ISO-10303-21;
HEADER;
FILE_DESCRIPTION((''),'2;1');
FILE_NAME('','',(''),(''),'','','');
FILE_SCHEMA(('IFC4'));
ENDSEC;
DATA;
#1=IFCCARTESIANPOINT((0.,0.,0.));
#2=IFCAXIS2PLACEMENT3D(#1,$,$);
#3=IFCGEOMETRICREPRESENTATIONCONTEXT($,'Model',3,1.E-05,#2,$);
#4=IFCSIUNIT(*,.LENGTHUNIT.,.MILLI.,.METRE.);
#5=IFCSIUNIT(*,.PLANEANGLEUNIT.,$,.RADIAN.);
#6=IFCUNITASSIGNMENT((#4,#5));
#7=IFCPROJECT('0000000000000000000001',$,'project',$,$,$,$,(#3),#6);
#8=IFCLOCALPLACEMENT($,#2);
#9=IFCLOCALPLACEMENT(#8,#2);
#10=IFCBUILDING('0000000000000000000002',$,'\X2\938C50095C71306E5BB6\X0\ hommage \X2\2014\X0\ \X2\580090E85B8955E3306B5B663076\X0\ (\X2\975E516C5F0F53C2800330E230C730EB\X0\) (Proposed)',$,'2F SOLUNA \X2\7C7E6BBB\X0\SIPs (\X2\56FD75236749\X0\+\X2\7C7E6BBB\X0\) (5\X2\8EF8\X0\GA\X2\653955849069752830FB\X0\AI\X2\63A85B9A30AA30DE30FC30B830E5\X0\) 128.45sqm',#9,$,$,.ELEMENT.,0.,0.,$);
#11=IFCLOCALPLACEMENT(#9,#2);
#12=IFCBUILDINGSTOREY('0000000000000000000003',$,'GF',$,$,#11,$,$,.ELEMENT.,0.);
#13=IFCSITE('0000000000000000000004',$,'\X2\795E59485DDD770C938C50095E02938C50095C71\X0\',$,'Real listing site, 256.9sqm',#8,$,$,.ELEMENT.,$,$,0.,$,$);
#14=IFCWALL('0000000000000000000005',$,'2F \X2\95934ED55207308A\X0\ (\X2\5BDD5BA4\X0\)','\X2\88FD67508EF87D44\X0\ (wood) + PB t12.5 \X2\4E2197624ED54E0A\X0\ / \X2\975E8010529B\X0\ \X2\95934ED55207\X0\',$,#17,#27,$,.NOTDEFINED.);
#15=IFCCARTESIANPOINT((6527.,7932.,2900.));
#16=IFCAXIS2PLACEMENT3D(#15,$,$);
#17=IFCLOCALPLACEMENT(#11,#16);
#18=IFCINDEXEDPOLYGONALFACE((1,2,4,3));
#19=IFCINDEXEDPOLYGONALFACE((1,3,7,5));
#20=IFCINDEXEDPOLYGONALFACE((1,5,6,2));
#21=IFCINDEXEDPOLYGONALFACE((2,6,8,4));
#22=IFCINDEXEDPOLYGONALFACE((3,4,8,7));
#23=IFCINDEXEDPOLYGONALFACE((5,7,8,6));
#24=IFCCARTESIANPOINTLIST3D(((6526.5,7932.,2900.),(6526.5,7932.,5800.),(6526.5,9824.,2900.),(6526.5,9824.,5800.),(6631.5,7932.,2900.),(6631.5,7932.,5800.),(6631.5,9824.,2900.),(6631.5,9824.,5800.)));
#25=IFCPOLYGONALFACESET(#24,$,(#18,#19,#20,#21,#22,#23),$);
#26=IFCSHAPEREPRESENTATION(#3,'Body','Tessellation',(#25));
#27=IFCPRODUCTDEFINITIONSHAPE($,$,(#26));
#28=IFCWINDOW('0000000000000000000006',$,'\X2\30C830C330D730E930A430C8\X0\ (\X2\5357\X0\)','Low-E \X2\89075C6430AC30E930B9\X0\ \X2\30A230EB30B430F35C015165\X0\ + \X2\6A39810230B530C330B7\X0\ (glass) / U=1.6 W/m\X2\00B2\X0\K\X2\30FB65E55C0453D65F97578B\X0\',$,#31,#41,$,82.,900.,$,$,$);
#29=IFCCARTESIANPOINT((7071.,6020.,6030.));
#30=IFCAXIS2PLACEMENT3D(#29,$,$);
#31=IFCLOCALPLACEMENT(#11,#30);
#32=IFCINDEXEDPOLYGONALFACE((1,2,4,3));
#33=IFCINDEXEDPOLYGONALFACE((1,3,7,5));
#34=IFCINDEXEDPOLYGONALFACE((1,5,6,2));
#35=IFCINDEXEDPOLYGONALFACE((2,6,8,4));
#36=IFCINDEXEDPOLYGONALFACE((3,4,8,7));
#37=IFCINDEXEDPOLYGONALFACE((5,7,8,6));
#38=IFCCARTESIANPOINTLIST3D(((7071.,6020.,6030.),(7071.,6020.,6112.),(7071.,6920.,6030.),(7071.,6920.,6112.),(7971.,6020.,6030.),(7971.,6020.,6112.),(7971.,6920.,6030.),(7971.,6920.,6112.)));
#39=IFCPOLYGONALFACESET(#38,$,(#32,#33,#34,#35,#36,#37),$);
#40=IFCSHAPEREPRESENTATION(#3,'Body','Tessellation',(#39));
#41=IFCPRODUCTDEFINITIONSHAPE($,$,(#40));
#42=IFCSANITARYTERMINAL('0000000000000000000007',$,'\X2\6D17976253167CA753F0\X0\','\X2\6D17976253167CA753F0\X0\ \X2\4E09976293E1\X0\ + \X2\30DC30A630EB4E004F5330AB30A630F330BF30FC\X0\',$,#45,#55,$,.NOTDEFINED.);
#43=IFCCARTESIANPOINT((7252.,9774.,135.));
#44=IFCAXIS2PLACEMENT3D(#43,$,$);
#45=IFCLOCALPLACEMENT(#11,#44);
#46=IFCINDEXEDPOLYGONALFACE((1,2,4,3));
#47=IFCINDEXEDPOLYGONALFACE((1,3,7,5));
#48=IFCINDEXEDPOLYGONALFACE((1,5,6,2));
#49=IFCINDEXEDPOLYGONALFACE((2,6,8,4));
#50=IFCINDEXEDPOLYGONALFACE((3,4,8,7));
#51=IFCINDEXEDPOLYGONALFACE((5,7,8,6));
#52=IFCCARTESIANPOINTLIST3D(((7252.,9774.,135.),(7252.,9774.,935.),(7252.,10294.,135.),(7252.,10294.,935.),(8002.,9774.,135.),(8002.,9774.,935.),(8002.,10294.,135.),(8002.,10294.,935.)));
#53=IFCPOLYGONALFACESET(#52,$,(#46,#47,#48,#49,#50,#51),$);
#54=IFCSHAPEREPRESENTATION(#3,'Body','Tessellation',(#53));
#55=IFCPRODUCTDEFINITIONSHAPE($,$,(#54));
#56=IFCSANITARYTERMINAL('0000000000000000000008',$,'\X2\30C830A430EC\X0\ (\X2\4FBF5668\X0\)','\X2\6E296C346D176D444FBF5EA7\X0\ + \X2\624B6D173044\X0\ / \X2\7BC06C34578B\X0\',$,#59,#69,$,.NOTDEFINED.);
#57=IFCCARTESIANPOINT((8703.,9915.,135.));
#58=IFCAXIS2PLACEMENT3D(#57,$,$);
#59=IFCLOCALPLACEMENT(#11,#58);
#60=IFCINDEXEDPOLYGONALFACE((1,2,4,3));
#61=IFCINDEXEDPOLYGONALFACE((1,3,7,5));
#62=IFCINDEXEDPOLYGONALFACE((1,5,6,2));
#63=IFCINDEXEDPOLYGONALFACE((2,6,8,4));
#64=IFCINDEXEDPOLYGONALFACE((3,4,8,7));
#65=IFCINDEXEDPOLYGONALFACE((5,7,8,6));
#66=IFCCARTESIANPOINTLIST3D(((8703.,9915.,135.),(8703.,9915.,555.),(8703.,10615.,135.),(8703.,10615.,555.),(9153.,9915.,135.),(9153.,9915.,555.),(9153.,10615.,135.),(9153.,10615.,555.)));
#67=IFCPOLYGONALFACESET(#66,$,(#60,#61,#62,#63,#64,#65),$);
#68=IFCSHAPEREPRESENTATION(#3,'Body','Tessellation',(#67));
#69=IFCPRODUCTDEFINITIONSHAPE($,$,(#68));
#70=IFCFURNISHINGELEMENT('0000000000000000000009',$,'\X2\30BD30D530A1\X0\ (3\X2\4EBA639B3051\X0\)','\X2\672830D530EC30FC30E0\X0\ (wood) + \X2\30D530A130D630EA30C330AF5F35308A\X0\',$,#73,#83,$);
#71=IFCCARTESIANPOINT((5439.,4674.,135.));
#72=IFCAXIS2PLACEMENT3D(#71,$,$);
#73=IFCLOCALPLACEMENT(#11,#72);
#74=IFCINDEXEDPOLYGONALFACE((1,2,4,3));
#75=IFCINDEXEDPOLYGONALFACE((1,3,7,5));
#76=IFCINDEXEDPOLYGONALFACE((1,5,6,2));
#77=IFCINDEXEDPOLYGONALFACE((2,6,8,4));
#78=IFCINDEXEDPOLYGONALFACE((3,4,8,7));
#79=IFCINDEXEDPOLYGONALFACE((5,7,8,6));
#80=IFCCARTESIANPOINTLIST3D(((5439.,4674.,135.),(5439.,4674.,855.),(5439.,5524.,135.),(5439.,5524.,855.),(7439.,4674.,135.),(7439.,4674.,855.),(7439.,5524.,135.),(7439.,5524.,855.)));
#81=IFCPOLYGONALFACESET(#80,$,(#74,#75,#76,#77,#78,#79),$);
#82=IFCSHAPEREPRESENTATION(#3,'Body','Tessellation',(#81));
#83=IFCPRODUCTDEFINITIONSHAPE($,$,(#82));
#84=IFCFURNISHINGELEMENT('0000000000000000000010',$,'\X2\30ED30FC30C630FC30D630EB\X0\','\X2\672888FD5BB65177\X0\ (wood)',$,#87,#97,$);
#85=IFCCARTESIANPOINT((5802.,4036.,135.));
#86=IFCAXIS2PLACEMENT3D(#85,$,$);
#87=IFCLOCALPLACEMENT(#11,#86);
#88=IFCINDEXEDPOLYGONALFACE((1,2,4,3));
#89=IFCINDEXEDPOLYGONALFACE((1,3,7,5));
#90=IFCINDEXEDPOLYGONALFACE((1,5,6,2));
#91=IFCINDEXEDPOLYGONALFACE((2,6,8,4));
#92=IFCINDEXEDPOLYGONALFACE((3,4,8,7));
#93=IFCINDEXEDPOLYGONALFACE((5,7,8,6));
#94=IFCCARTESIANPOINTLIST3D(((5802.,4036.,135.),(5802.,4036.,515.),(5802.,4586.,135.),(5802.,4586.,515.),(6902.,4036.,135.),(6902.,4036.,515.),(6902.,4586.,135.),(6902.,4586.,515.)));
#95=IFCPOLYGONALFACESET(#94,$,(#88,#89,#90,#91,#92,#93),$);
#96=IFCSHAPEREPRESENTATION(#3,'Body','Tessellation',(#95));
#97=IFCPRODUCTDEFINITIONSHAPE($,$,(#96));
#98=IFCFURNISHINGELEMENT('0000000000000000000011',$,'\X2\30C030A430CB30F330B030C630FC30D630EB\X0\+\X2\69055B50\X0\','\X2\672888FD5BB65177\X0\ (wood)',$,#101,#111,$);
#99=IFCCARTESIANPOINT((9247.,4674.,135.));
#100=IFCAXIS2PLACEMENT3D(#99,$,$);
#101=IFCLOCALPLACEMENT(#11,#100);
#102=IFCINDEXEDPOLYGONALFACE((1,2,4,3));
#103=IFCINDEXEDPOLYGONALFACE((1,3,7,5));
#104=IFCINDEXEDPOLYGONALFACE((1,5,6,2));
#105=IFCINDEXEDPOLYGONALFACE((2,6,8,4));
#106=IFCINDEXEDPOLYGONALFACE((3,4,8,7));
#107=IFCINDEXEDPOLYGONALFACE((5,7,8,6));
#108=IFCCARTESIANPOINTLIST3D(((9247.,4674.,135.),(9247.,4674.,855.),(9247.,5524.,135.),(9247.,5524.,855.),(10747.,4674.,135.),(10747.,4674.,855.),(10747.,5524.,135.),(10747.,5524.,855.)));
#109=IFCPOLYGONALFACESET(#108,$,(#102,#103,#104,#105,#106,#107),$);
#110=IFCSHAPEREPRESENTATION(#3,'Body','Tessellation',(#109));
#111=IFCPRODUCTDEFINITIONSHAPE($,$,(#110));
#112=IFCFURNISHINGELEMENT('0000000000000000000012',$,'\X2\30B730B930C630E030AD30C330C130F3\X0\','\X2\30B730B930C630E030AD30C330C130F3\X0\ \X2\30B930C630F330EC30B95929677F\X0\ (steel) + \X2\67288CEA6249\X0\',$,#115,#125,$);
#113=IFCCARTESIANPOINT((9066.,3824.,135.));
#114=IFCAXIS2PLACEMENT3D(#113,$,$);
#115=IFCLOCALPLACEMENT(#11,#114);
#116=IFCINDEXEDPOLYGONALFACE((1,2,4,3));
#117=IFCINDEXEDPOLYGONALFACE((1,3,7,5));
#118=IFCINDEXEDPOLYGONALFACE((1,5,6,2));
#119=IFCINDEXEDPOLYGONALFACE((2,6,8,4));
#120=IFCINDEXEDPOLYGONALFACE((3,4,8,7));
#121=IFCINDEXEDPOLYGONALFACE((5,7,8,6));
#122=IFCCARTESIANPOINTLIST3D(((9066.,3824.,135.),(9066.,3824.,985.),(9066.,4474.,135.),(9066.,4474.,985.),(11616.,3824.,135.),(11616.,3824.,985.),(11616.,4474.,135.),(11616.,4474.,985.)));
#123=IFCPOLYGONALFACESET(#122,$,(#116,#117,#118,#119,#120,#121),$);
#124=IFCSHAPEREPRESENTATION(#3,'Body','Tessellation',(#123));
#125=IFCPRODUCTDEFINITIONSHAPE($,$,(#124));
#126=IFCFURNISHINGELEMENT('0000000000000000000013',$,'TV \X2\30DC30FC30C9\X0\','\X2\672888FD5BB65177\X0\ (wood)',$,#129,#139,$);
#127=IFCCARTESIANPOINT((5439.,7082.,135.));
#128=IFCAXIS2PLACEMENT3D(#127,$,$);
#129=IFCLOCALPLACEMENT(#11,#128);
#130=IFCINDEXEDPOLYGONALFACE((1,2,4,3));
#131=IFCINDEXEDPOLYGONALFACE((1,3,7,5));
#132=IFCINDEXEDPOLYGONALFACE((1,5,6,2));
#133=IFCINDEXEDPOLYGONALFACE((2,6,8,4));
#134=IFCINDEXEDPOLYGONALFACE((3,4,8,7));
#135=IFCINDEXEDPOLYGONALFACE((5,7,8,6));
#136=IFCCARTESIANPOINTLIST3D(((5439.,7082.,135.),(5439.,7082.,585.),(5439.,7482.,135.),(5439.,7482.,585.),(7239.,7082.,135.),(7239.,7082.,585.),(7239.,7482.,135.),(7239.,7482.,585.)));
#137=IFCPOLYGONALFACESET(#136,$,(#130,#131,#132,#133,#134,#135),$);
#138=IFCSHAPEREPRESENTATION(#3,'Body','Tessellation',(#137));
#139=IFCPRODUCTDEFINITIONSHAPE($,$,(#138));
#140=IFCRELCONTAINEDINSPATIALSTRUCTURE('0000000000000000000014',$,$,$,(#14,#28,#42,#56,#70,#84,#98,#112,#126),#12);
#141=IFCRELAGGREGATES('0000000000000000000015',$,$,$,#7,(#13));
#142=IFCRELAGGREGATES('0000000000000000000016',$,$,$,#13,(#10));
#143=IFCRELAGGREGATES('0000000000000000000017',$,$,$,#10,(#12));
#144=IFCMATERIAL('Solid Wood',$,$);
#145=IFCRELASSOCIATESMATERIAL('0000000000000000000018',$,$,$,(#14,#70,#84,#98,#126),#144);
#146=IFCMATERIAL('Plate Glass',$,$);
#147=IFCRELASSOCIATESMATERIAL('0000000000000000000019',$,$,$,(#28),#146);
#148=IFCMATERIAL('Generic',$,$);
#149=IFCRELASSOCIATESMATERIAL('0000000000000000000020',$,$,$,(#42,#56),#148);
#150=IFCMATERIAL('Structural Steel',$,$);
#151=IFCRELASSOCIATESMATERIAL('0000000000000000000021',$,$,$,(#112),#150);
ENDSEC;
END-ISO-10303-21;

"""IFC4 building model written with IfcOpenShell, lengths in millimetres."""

from ifc_helpers import new_model, si_unit, frame, frame_2d, origin, place, context, project, spatial, rectangle, extrude, material, element, save


model = new_model("IFC4")

# Units and contexts
model_context = context("Model", 3, precision=1e-05, world=origin())
ifc_project = project(units=[si_unit("LENGTHUNIT", "METRE", prefix="MILLI"), si_unit("PLANEANGLEUNIT", "RADIAN")], contexts=[model_context])

# Site, building, storey
site_placement = place(None, origin())
site = spatial("IfcSite", under=ifc_project, at=site_placement, Name="神奈川県鎌倉市鎌倉山", ObjectType="Real listing site, 256.9sqm", CompositionType="ELEMENT", RefElevation=0.0)
building_placement = place(site_placement, origin())
building = spatial("IfcBuilding", under=site, at=building_placement, Name="鎌倉山の家 hommage — 堀部安嗣に学ぶ (非公式参考モデル) (Proposed)", ObjectType="2F SOLUNA 籾殻SIPs (国産杉+籾殻) (5軸GA改善適用・AI推定オマージュ) 128.45sqm", CompositionType="ELEMENT", ElevationOfRefHeight=0.0, ElevationOfTerrain=0.0)
storey_placement = place(building_placement, origin())
storey = spatial("IfcBuildingStorey", under=building, at=storey_placement, Name="GF", CompositionType="ELEMENT", Elevation=0.0)

# Shared definitions
ifc_material_1 = material(Name="Solid Wood")

# Wall
wall_1_placement = place(storey_placement, frame((6527.0, 7932.0, 2900.0)))
element("IfcWall", 1, at=wall_1_placement, inside=storey, material=ifc_material_1, Name="2F 間仕切り (寝室)", Description="製材軸組 (wood) + PB t12.5 両面仕上 / 非耐力 間仕切", PredefinedType="NOTDEFINED", context=model_context, shape_type="SweptSolid", body=[
    extrude(rectangle(XDim=105.0, YDim=1892.0, at=frame_2d((52.0, 946.0))), frame((6527.0, 7932.0, 2900.0)), (0.0, 0.0, 1.0), 2900.0),
])

# Window
ifc_material_2 = material(Name="Plate Glass")
window_placement = place(storey_placement, frame((7071.0, 6020.0, 6030.0)))
element("IfcWindow", 2, at=window_placement, inside=storey, material=ifc_material_2, Name="トップライト (南)", Description="Low-E 複層ガラス アルゴン封入 + 樹脂サッシ (glass) / U=1.6 W/m²K・日射取得型", OverallHeight=82.0, OverallWidth=900.0, context=model_context, shape_type="SweptSolid", body=[
    extrude(rectangle(XDim=900.0, YDim=900.0, at=frame_2d((450.0, 450.0))), frame((7071.0, 6020.0, 6030.0)), (0.0, 0.0, 1.0), 82.0),
])

# Sanitary terminals
ifc_material_3 = material(Name="Generic")
sanitary_terminal_1_placement = place(storey_placement, frame((7252.0, 9774.0, 135.0)))
element("IfcSanitaryTerminal", 3, at=sanitary_terminal_1_placement, inside=storey, material=ifc_material_3, Name="洗面化粧台", Description="洗面化粧台 三面鏡 + ボウル一体カウンター", PredefinedType="NOTDEFINED", context=model_context, shape_type="SweptSolid", body=[
    extrude(rectangle(XDim=750.0, YDim=520.0, at=frame_2d((375.0, 260.0))), frame((7252.0, 9774.0, 135.0)), (0.0, 0.0, 1.0), 800.0),
])
sanitary_terminal_2_placement = place(storey_placement, frame((8703.0, 9915.0, 135.0)))
element("IfcSanitaryTerminal", 4, at=sanitary_terminal_2_placement, inside=storey, material=ifc_material_3, Name="トイレ (便器)", Description="温水洗浄便座 + 手洗い / 節水型", PredefinedType="NOTDEFINED", context=model_context, shape_type="SweptSolid", body=[
    extrude(rectangle(XDim=450.0, YDim=700.0, at=frame_2d((225.0, 350.0))), frame((8703.0, 9915.0, 135.0)), (0.0, 0.0, 1.0), 420.0),
])

# Furnishing elements
furnishing_1_placement = place(storey_placement, frame((5439.0, 4674.0, 135.0)))
element("IfcFurnishingElement", 5, at=furnishing_1_placement, inside=storey, material=ifc_material_1, Name="ソファ (3人掛け)", Description="木フレーム (wood) + ファブリック張り", context=model_context, shape_type="SweptSolid", body=[
    extrude(rectangle(XDim=2000.0, YDim=850.0, at=frame_2d((1000.0, 425.0))), frame((5439.0, 4674.0, 135.0)), (0.0, 0.0, 1.0), 720.0),
])
furnishing_2_placement = place(storey_placement, frame((5802.0, 4036.0, 135.0)))
element("IfcFurnishingElement", 6, at=furnishing_2_placement, inside=storey, material=ifc_material_1, Name="ローテーブル", Description="木製家具 (wood)", context=model_context, shape_type="SweptSolid", body=[
    extrude(rectangle(XDim=1100.0, YDim=550.0, at=frame_2d((550.0, 275.0))), frame((5802.0, 4036.0, 135.0)), (0.0, 0.0, 1.0), 380.0),
])
furnishing_3_placement = place(storey_placement, frame((9247.0, 4674.0, 135.0)))
element("IfcFurnishingElement", 7, at=furnishing_3_placement, inside=storey, material=ifc_material_1, Name="ダイニングテーブル+椅子", Description="木製家具 (wood)", context=model_context, shape_type="SweptSolid", body=[
    extrude(rectangle(XDim=1500.0, YDim=850.0, at=frame_2d((750.0, 425.0))), frame((9247.0, 4674.0, 135.0)), (0.0, 0.0, 1.0), 720.0),
])
ifc_material_4 = material(Name="Structural Steel")
furnishing_4_placement = place(storey_placement, frame((9066.0, 3824.0, 135.0)))
element("IfcFurnishingElement", 8, at=furnishing_4_placement, inside=storey, material=ifc_material_4, Name="システムキッチン", Description="システムキッチン ステンレス天板 (steel) + 木質扉", context=model_context, shape_type="SweptSolid", body=[
    extrude(rectangle(XDim=2550.0, YDim=650.0, at=frame_2d((1275.0, 325.0))), frame((9066.0, 3824.0, 135.0)), (0.0, 0.0, 1.0), 850.0),
])
furnishing_5_placement = place(storey_placement, frame((5439.0, 7082.0, 135.0)))
element("IfcFurnishingElement", 9, at=furnishing_5_placement, inside=storey, material=ifc_material_1, Name="TV ボード", Description="木製家具 (wood)", context=model_context, shape_type="SweptSolid", body=[
    extrude(rectangle(XDim=1800.0, YDim=400.0, at=frame_2d((900.0, 200.0))), frame((5439.0, 7082.0, 135.0)), (0.0, 0.0, 1.0), 450.0),
])

save(model, "model.ifc")
